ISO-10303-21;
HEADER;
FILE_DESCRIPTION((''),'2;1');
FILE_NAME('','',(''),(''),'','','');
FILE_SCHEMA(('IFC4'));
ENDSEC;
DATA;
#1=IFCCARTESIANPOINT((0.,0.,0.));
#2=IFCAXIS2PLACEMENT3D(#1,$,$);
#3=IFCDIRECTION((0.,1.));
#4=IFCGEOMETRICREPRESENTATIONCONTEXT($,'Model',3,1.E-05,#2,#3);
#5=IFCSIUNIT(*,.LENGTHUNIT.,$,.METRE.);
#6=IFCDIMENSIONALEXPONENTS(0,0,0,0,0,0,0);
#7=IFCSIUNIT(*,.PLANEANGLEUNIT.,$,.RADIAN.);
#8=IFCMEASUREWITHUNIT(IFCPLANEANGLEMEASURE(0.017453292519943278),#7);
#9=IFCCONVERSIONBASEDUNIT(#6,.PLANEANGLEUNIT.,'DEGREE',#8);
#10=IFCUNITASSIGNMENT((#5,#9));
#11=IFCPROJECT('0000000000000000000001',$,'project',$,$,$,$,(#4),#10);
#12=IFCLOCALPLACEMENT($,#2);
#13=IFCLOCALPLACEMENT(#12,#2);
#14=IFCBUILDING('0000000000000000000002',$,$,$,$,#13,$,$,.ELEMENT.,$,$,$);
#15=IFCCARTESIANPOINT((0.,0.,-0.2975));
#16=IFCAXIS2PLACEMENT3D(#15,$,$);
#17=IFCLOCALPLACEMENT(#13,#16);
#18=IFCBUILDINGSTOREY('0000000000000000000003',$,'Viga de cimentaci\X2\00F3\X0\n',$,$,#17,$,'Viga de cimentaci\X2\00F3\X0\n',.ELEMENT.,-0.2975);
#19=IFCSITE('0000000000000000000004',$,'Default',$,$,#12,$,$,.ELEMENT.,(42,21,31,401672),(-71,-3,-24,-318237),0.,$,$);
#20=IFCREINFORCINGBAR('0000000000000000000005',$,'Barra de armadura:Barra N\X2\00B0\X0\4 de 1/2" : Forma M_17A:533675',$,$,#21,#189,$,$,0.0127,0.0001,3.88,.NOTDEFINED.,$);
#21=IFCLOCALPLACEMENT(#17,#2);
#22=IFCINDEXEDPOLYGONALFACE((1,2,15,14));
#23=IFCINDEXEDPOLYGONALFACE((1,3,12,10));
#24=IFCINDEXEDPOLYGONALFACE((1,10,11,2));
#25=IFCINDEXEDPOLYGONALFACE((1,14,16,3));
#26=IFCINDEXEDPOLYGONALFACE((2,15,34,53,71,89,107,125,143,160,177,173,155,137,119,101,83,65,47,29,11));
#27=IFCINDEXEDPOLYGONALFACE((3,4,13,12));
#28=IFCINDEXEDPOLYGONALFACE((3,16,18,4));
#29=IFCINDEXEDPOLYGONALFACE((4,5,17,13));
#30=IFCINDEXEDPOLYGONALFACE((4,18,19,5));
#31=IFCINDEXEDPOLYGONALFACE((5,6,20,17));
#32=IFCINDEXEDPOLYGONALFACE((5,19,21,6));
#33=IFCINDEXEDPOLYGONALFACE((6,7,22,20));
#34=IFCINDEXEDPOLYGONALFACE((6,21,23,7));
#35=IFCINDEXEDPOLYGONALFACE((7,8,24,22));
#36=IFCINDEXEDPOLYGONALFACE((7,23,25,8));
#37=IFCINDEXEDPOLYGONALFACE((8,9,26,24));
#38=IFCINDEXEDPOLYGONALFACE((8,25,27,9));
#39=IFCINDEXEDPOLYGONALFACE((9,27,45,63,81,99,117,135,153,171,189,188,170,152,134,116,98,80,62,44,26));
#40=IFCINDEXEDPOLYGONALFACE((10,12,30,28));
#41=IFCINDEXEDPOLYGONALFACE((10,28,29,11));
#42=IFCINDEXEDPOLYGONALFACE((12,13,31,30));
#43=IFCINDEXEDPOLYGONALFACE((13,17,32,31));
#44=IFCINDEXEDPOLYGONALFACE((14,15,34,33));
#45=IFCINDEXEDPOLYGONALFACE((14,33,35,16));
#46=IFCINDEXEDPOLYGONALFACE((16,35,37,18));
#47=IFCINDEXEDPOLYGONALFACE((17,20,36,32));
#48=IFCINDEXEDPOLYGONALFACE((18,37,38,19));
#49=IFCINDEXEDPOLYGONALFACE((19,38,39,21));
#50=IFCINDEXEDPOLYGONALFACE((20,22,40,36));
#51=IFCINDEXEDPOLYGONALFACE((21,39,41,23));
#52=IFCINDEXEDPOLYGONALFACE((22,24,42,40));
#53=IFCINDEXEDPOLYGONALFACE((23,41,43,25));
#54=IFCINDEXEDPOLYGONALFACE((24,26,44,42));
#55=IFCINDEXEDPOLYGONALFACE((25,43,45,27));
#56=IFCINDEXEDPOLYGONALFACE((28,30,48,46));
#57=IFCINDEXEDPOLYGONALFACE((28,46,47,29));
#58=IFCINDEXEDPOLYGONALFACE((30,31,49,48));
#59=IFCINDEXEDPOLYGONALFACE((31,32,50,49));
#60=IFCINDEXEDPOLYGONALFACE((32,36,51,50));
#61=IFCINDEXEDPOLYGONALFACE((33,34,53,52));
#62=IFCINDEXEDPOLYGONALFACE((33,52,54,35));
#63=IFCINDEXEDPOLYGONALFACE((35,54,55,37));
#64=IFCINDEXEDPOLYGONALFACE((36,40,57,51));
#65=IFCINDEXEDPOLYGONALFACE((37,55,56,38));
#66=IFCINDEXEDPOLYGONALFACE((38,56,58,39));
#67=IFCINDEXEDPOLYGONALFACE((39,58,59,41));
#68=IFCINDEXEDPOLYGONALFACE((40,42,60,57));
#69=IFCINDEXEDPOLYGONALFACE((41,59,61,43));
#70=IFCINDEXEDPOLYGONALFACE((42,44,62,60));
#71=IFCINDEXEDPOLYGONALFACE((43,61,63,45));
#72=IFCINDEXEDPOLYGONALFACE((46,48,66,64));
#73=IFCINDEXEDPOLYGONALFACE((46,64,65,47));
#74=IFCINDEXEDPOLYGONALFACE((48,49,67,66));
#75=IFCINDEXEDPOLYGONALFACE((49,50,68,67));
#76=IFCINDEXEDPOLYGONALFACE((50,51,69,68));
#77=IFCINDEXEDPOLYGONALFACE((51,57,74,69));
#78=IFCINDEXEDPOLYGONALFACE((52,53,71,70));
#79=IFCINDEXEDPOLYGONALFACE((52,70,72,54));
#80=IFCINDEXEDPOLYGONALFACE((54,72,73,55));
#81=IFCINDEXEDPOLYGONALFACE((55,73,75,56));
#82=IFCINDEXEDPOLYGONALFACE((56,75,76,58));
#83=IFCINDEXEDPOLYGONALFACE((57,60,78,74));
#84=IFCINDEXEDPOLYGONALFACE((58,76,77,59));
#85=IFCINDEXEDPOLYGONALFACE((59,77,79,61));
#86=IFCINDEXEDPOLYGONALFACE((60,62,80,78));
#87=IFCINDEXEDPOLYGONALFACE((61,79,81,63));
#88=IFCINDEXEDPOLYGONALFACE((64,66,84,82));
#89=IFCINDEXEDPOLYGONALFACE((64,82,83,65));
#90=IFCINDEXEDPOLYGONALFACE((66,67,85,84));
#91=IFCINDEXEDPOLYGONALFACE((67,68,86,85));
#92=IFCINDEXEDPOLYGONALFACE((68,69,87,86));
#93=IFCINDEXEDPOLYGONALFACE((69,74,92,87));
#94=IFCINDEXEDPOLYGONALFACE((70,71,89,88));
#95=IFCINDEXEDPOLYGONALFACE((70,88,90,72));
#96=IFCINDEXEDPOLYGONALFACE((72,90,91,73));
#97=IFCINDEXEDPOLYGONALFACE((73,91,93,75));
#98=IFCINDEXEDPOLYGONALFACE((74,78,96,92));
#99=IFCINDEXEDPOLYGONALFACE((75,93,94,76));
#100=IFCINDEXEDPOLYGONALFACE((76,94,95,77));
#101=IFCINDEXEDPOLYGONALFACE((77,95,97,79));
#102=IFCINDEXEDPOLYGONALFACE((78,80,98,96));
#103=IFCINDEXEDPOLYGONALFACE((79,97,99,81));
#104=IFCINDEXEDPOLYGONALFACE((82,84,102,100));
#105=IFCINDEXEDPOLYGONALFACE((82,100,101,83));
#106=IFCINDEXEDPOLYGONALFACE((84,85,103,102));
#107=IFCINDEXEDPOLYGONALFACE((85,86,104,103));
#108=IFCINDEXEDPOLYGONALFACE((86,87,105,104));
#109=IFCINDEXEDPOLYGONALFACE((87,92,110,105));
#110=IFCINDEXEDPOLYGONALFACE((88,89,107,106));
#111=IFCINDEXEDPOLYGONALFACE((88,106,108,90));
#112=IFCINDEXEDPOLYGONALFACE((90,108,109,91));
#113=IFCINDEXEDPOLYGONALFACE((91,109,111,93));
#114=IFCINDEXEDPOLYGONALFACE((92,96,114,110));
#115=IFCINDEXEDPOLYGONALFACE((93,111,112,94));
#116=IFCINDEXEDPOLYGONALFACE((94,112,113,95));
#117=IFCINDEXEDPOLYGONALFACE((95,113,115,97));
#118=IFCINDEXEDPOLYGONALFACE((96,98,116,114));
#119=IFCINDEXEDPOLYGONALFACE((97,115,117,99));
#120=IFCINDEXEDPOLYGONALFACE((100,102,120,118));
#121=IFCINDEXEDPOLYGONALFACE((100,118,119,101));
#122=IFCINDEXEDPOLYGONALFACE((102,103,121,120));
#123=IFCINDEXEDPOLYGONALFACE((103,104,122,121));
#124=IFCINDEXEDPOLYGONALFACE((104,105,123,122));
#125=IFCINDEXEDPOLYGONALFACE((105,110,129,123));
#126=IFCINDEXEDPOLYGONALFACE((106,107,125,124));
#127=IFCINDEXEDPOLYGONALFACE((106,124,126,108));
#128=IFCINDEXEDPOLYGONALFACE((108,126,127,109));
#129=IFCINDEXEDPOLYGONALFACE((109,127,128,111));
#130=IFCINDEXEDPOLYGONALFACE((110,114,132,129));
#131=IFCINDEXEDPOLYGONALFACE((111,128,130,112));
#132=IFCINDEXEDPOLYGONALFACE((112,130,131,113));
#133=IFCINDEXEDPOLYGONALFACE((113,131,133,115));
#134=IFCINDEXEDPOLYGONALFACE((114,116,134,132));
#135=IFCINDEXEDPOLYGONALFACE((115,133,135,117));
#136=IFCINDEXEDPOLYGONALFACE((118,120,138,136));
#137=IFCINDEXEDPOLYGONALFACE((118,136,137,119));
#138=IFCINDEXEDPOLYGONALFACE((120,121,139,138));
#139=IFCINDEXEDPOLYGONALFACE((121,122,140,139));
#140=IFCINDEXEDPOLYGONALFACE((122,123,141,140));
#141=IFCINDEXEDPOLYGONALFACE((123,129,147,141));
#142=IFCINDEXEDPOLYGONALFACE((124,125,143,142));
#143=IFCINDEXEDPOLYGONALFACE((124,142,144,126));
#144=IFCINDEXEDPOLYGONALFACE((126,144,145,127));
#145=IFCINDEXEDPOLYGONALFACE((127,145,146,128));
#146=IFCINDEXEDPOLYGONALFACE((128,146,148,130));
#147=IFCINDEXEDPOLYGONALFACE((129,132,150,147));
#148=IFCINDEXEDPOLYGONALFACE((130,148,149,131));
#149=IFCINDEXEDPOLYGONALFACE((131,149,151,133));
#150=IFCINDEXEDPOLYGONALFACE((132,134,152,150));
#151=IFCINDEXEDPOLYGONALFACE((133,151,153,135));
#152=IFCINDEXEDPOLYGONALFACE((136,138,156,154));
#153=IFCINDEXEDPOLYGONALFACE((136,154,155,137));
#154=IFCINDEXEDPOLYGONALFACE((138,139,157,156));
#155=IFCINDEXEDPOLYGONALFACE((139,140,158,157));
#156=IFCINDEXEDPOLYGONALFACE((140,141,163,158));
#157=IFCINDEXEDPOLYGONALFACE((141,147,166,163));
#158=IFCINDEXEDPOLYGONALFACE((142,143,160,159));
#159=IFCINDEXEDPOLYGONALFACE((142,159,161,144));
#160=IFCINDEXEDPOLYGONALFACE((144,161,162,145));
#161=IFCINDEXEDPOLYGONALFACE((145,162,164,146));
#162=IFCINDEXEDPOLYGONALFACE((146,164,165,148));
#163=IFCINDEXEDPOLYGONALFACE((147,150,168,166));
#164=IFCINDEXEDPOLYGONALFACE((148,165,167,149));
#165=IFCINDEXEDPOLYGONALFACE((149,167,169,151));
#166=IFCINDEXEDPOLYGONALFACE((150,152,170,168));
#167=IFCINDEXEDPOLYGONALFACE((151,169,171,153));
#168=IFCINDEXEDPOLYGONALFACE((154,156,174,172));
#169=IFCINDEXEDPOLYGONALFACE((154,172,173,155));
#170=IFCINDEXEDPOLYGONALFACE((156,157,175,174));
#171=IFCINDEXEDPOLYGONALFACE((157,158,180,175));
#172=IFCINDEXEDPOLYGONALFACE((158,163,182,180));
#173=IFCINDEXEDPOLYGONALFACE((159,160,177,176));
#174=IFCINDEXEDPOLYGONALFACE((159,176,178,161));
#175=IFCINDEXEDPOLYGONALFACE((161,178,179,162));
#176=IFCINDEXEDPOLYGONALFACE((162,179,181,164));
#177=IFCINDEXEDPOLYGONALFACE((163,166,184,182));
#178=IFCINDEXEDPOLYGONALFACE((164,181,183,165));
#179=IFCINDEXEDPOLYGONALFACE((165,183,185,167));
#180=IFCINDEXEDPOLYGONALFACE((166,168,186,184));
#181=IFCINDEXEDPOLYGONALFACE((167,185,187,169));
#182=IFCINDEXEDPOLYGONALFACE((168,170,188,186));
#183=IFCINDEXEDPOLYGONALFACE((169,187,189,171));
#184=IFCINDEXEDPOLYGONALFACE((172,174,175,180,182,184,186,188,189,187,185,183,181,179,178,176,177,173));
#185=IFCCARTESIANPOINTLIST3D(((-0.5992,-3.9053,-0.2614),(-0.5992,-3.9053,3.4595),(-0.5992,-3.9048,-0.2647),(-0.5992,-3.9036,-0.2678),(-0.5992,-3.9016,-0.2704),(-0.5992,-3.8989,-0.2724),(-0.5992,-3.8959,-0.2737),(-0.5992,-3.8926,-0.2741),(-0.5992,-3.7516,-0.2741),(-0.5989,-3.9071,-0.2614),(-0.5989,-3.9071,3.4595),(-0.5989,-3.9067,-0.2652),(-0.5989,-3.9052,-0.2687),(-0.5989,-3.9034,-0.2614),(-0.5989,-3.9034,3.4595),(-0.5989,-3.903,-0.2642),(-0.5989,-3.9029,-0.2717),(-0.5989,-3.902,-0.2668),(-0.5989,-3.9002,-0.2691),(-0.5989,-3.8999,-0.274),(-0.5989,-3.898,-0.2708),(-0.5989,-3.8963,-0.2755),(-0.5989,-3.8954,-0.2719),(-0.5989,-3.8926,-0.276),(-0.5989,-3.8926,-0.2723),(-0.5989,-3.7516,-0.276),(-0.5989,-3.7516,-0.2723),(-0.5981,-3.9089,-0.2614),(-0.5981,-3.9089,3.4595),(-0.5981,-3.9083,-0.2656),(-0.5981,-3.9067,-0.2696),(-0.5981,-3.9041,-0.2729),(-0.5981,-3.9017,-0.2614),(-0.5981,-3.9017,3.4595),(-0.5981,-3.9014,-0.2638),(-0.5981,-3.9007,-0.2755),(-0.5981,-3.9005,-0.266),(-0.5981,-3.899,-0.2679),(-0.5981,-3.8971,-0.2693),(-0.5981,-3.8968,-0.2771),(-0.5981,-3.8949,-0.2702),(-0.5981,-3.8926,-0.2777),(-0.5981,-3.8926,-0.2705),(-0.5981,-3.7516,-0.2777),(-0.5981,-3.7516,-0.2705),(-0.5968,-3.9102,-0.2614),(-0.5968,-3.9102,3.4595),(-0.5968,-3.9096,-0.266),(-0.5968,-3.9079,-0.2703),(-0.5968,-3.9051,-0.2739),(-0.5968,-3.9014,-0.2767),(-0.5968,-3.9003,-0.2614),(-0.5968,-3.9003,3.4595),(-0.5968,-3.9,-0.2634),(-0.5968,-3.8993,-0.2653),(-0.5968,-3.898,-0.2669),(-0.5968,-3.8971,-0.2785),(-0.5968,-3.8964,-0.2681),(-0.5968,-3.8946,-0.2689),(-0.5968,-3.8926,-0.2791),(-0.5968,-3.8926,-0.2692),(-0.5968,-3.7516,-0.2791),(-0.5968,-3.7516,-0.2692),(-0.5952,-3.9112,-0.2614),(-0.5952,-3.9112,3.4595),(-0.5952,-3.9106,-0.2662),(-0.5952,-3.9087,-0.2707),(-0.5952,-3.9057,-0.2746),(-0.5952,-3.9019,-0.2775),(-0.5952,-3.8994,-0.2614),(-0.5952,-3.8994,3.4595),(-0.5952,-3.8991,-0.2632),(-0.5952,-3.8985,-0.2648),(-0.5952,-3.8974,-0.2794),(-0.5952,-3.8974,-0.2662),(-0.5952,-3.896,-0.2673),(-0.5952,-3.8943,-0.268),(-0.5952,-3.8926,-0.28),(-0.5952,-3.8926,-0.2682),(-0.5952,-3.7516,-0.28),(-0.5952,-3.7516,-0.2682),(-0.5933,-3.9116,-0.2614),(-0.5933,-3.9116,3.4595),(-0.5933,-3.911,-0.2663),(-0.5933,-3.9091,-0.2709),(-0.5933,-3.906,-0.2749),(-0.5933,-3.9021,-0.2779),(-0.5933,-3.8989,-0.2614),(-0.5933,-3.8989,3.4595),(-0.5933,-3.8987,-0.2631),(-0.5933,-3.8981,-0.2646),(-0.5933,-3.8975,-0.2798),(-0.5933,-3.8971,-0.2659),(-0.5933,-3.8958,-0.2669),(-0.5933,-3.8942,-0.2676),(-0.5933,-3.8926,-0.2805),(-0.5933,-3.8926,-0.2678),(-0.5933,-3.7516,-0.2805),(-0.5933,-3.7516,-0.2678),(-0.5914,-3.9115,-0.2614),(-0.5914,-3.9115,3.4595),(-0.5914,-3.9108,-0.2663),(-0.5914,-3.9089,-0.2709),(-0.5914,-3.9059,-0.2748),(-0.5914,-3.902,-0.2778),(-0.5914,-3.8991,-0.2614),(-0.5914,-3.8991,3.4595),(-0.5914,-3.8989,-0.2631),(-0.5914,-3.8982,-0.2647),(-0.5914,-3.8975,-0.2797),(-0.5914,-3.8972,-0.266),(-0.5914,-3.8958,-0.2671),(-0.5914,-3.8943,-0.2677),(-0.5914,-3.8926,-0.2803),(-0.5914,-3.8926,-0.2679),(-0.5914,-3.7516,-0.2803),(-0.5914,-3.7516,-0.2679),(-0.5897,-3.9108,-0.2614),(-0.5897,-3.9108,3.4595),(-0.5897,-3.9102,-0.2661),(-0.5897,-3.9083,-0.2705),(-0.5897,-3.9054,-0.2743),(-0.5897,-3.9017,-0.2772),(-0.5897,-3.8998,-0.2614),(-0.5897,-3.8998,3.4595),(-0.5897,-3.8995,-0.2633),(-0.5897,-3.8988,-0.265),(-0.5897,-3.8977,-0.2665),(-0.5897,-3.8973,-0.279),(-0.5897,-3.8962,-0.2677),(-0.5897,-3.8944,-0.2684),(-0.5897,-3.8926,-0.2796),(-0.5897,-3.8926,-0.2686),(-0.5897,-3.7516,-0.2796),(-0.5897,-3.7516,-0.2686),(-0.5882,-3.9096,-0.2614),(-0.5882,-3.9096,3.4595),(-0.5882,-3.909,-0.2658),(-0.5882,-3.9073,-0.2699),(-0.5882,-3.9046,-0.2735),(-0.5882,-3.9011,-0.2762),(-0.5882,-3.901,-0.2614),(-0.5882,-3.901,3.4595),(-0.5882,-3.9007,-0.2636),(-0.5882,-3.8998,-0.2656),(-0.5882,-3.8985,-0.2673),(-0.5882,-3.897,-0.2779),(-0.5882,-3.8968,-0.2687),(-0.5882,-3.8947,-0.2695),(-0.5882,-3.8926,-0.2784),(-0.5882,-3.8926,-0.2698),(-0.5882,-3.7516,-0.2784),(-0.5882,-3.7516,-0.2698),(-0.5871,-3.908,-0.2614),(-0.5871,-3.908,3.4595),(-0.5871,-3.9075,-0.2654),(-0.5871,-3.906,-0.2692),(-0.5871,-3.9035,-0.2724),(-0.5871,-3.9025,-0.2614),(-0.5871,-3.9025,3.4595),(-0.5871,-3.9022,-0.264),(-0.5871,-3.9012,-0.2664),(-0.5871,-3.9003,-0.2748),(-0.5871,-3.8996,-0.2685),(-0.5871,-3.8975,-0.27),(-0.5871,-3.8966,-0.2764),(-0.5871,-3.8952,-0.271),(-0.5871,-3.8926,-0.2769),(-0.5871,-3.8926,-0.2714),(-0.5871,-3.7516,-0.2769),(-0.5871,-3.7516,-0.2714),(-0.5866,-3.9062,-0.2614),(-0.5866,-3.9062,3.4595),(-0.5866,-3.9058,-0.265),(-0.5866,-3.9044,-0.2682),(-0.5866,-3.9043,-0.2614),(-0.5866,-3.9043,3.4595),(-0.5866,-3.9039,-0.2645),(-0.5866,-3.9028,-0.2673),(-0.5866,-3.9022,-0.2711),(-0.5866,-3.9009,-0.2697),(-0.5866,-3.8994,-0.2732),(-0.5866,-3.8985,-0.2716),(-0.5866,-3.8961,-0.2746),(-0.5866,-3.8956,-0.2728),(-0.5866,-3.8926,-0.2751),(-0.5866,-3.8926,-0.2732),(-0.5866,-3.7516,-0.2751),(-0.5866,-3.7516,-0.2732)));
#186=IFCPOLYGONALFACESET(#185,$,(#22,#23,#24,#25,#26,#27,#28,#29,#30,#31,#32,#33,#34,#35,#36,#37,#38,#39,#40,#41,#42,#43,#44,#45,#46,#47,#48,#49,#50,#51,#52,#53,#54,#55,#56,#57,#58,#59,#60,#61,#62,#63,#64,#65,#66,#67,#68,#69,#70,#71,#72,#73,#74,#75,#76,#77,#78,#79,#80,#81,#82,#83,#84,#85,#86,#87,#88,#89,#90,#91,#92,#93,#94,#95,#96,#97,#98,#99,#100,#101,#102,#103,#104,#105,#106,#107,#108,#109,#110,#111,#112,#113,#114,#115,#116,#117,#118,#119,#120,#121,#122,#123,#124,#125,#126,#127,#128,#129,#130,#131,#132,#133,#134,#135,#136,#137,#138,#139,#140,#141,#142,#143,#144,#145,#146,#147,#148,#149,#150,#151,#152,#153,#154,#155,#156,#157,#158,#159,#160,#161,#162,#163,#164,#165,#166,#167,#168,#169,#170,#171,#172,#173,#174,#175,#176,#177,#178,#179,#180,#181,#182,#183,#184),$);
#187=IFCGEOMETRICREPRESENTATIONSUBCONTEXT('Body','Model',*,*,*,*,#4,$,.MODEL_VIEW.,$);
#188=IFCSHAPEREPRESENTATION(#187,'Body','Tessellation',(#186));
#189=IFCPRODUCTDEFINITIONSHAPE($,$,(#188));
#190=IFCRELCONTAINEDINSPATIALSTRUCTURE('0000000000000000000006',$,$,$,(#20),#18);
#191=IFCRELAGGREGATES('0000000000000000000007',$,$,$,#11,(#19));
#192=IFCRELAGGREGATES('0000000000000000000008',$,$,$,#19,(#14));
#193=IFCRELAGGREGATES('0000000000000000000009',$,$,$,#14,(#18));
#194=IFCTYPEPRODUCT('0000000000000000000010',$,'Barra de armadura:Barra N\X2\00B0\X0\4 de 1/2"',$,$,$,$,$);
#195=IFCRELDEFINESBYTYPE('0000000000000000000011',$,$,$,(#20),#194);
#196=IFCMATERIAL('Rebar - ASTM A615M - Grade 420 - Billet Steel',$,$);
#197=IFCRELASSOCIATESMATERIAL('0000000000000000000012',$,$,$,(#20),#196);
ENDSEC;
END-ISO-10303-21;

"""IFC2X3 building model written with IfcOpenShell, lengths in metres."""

from ifc_helpers import new_model, entity, si_unit, converted_unit, direction, frame, origin, place, context, subcontext, project, spatial, material, type_object, element, save


model = new_model("IFC2X3")

# Units and contexts
model_context = context("Model", 3, precision=1e-05, world=origin(), true_north=direction((0.0, 1.0)))
body_context = subcontext(model_context, "Body", "Model", "MODEL_VIEW")
ifc_project = project(units=[si_unit("LENGTHUNIT", "METRE"), converted_unit("PLANEANGLEUNIT", "DEGREE", entity("IfcPlaneAngleMeasure", 0.017453292519943278), si_unit("PLANEANGLEUNIT", "RADIAN"), dimensions=[0, 0, 0, 0, 0, 0, 0])], contexts=[model_context])

# Site, building, storey
site_placement = place(None, origin())
site = spatial("IfcSite", under=ifc_project, at=site_placement, Name="Default", CompositionType="ELEMENT", RefLatitude=(42, 21, 31, 401672), RefLongitude=(-71, -3, -24, -318237), RefElevation=0.0)
building_placement = place(site_placement, origin())
building = spatial("IfcBuilding", under=site, at=building_placement, CompositionType="ELEMENT")
storey_placement = place(building_placement, frame((0.0, 0.0, -0.2975)))
storey = spatial("IfcBuildingStorey", under=building, at=storey_placement, Name="Viga de cimentación", LongName="Viga de cimentación", CompositionType="ELEMENT", Elevation=-0.2975)

# Reinforcing bar
ifc_material = material(Name="Rebar - ASTM A615M - Grade 420 - Billet Steel")
type_product_1 = type_object("IfcTypeProduct", Name="Barra de armadura:Barra N°4 de 1/2\"")
reinforcing_bar_1_placement = place(storey_placement, origin())
element("IfcReinforcingBar", 1, at=reinforcing_bar_1_placement, inside=storey, type_object=type_product_1, material=ifc_material, Name="Barra de armadura:Barra N°4 de 1/2\" : Forma M_17A:533675", BarLength=3.88, BarRole="NOTDEFINED", CrossSectionArea=0.0001, NominalDiameter=0.0127, context=body_context, shape_type="AdvancedSweptSolid", body=[
    entity("IfcSweptDiskSolid", entity("IfcCompositeCurve", [entity("IfcCompositeCurveSegment", "CONTINUOUS", True, entity("IfcPolyline", [entity("IfcCartesianPoint", [-0.5929, -3.9053, 3.4595]), entity("IfcCartesianPoint", [-0.5929, -3.9053, -0.2614])])), entity("IfcCompositeCurveSegment", "CONTINUOUS", True, entity("IfcTrimmedCurve", entity("IfcCircle", entity("IfcAxis2Placement3D", entity("IfcCartesianPoint", [-0.5929, -3.8926, -0.2614]), entity("IfcDirection", [1.0, 0.0, 0.0]), entity("IfcDirection", [0.0, 0.0, -1.0])), 0.0127), [entity("IfcParameterValue", 270.0)], [entity("IfcParameterValue", 360.0)], True, "PARAMETER")), entity("IfcCompositeCurveSegment", "CONTINUOUS", True, entity("IfcPolyline", [entity("IfcCartesianPoint", [-0.5929, -3.8926, -0.2741]), entity("IfcCartesianPoint", [-0.5929, -3.7516, -0.2741])]))], False), 0.0063, None, 0.0, 92.0),
])

save(model, "model.ifc")
